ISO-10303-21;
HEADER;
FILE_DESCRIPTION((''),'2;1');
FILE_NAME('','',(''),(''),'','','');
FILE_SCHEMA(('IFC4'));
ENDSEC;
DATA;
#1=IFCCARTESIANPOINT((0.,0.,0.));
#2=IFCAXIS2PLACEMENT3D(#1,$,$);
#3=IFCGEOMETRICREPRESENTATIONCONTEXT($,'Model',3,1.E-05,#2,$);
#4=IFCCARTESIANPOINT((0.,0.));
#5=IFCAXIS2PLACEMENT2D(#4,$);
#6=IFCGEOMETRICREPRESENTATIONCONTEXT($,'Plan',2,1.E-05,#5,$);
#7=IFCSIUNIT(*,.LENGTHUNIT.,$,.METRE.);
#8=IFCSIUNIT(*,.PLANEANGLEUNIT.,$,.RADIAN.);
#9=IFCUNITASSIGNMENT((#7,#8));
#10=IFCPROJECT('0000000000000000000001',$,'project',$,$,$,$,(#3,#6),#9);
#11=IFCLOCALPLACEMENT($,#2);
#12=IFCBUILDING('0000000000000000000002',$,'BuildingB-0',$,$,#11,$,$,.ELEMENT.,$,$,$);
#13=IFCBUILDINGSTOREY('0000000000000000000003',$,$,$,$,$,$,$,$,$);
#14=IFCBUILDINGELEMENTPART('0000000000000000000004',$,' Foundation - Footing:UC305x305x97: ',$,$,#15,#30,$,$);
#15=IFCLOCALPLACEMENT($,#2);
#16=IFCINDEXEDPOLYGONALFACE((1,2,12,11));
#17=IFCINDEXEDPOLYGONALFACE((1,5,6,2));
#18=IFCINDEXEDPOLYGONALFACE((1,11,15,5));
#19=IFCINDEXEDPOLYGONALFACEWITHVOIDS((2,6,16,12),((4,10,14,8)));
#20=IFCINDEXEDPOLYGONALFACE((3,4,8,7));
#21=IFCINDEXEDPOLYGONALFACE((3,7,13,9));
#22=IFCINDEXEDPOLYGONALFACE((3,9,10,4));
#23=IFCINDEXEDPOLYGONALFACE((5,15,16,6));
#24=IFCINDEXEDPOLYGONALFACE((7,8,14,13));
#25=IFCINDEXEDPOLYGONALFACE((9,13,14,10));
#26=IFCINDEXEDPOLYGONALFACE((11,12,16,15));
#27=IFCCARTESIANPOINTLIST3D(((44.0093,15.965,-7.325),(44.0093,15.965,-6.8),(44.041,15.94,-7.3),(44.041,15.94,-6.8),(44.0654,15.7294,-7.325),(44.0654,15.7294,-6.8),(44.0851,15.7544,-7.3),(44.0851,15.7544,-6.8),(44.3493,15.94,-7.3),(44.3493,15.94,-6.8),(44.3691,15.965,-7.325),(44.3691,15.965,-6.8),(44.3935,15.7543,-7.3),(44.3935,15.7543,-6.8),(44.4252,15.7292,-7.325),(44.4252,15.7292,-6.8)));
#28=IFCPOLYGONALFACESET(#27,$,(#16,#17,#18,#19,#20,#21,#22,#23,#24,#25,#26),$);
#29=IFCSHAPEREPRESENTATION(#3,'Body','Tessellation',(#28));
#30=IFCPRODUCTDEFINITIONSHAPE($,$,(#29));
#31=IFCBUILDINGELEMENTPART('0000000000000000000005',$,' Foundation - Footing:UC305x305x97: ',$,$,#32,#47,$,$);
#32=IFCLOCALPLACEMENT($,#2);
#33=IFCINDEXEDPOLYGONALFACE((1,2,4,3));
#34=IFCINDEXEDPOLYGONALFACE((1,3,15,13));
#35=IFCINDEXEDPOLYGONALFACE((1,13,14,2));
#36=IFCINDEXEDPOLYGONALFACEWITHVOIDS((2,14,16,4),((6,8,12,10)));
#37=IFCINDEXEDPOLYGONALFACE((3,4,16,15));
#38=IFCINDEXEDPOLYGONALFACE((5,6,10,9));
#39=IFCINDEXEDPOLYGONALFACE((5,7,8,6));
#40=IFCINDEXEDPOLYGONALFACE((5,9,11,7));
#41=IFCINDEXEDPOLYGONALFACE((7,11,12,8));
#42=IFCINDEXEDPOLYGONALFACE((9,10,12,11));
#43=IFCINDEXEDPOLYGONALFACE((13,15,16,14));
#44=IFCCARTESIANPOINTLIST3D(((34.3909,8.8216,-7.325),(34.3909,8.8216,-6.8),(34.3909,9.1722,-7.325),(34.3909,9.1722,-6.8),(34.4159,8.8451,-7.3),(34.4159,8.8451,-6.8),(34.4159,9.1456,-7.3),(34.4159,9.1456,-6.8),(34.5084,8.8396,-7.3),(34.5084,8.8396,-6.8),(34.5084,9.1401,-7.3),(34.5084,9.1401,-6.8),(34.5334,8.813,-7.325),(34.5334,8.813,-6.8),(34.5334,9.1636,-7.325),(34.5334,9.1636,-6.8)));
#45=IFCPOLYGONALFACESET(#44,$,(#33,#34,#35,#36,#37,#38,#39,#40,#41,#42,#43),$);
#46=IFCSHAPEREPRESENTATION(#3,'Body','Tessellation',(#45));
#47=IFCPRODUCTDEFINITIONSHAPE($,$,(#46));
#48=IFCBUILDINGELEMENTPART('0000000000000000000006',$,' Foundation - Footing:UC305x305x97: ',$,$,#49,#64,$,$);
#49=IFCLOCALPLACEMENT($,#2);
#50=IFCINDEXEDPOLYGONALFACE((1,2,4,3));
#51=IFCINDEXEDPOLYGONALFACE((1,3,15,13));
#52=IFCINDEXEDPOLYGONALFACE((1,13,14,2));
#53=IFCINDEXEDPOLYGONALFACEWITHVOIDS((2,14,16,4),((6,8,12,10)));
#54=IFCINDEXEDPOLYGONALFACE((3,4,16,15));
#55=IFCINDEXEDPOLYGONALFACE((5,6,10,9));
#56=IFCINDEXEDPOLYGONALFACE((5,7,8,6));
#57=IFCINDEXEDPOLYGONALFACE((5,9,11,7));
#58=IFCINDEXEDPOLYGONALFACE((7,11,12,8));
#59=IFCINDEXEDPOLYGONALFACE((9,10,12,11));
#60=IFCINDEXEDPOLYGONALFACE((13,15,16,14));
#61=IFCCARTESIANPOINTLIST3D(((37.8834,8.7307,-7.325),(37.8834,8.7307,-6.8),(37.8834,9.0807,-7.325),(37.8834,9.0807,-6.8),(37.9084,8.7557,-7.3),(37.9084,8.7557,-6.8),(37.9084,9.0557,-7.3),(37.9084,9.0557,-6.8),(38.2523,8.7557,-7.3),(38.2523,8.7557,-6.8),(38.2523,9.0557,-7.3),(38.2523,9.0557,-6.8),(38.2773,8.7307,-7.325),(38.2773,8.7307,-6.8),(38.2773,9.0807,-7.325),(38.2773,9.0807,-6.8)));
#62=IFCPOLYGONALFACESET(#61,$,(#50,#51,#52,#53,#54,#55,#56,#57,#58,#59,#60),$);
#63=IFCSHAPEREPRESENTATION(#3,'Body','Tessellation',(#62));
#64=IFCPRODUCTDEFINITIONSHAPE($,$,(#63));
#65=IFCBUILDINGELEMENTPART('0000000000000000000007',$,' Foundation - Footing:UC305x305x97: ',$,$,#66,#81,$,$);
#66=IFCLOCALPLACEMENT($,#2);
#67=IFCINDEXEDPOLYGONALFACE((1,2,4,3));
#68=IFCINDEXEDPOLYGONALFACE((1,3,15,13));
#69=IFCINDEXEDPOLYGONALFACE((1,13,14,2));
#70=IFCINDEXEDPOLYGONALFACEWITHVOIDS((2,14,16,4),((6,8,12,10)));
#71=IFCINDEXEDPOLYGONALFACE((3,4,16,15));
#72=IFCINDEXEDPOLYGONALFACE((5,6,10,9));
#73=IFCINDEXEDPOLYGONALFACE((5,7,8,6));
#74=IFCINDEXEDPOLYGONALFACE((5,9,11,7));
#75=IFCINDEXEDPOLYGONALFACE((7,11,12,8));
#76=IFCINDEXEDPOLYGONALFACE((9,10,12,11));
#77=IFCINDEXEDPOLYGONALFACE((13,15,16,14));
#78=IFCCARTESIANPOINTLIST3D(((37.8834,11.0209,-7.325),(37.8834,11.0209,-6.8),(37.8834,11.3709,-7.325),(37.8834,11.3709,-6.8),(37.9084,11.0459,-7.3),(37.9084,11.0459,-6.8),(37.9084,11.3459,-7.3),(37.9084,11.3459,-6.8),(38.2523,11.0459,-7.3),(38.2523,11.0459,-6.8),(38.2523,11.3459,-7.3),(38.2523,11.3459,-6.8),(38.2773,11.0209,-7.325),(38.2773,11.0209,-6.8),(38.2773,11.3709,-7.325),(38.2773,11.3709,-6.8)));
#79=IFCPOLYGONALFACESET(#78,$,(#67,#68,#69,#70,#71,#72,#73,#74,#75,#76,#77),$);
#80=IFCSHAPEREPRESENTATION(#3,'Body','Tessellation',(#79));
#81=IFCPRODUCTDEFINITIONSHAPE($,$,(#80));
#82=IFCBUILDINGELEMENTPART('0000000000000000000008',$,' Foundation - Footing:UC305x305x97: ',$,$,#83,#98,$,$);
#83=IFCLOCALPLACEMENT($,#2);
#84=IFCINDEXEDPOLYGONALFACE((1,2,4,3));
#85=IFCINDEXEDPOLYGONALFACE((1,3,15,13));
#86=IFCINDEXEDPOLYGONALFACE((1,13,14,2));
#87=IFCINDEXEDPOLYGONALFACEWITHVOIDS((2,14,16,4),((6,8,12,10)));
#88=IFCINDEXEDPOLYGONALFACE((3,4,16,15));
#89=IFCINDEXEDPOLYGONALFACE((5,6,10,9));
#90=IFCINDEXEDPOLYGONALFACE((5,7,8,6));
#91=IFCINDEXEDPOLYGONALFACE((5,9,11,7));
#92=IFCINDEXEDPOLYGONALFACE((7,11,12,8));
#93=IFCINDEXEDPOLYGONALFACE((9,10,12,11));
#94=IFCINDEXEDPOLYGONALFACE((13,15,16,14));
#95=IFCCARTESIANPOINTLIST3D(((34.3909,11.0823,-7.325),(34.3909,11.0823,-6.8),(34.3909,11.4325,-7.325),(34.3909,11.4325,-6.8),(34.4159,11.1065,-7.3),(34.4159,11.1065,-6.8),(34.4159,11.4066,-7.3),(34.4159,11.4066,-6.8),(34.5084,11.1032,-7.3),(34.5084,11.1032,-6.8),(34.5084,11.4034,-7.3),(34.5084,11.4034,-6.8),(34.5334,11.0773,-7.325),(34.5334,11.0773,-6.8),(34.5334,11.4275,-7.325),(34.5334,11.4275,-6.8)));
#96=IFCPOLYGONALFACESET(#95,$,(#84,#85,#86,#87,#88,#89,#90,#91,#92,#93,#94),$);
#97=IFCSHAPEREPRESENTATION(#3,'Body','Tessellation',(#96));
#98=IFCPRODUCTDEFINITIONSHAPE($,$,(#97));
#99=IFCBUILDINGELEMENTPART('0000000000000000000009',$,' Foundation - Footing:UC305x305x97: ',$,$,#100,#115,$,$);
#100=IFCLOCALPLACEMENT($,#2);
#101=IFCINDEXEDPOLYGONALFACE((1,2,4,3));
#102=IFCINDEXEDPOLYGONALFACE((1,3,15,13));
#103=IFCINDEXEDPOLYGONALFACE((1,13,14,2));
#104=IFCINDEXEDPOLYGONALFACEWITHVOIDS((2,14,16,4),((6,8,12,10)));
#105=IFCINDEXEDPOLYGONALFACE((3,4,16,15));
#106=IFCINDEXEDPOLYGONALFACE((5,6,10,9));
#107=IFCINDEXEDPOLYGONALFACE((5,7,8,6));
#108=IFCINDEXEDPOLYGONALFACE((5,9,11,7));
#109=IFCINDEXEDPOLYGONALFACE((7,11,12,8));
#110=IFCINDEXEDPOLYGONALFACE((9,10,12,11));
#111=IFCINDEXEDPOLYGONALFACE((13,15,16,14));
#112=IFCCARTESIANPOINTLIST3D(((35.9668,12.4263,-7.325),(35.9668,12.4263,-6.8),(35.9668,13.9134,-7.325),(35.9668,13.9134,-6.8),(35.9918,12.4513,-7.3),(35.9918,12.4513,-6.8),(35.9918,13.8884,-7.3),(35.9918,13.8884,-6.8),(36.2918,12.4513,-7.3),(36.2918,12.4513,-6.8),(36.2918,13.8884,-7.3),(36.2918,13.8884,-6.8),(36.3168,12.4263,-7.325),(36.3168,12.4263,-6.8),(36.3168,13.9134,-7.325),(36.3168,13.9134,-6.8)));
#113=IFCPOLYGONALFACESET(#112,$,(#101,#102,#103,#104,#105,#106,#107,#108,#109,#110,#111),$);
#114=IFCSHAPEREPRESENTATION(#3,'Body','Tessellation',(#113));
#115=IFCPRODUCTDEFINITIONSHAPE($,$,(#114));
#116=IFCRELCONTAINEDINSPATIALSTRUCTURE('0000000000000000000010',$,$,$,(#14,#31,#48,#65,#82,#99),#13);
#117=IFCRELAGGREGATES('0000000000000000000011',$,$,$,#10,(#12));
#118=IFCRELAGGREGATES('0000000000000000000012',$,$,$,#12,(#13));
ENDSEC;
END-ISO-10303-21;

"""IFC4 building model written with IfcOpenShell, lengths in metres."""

from ifc_helpers import new_model, si_unit, origin, origin_2d, place, context, project, spatial, polyline, outline, extrude, element, save


model = new_model("IFC4")

# Units and contexts
model_context = context("Model", 3, precision=1e-05, world=origin())
plan_context = context("Plan", 2, precision=1e-05, world=origin_2d())
ifc_project = project(units=[si_unit("LENGTHUNIT", "METRE"), si_unit("PLANEANGLEUNIT", "RADIAN")], contexts=[model_context, plan_context])

# Building, storey
building_placement = place(None, origin())
building = spatial("IfcBuilding", under=ifc_project, at=building_placement, Name="BuildingB-0", CompositionType="ELEMENT")
storey = spatial("IfcBuildingStorey", under=building)

# Building element parts, openings
building_element_part_1 = element("IfcBuildingElementPart", 1, inside=storey, Name=" Foundation - Footing:UC305x305x97: ", context=model_context, shape_type="SweptSolid", body=[
    extrude(outline(polyline([(44.0654, 15.7294, -7.325), (44.0093, 15.965, -7.325), (44.3691, 15.965, -7.325), (44.4252, 15.7292, -7.325), (44.0654, 15.7294, -7.325)])), None, (0.0, 0.0, 1.0), 0.525),
])
element("IfcOpeningElement", 2, inside=storey, cuts=building_element_part_1, context=model_context, shape_type="SweptSolid", body=[
    extrude(outline(polyline([(44.0851, 15.7544, -7.3), (44.041, 15.94, -7.3), (44.3493, 15.94, -7.3), (44.3935, 15.7543, -7.3), (44.0851, 15.7544, -7.3)])), None, (0.0, 0.0, 1.0), 0.5),
])
building_element_part_2 = element("IfcBuildingElementPart", 3, inside=storey, Name=" Foundation - Footing:UC305x305x97: ", context=model_context, shape_type="SweptSolid", body=[
    extrude(outline(polyline([(34.3909, 8.8216, -7.325), (34.5334, 8.813, -7.325), (34.5334, 9.1636, -7.325), (34.3909, 9.1722, -7.325), (34.3909, 8.8216, -7.325)])), None, (0.0, 0.0, 1.0), 0.525),
])
element("IfcOpeningElement", 4, inside=storey, cuts=building_element_part_2, context=model_context, shape_type="SweptSolid", body=[
    extrude(outline(polyline([(34.4159, 8.8451, -7.3), (34.5084, 8.8396, -7.3), (34.5084, 9.1401, -7.3), (34.4159, 9.1456, -7.3), (34.4159, 8.8451, -7.3)])), None, (0.0, 0.0, 1.0), 0.5),
])
building_element_part_3 = element("IfcBuildingElementPart", 5, inside=storey, Name=" Foundation - Footing:UC305x305x97: ", context=model_context, shape_type="SweptSolid", body=[
    extrude(outline(polyline([(37.8834, 8.7307, -7.325), (38.2773, 8.7307, -7.325), (38.2773, 9.0807, -7.325), (37.8834, 9.0807, -7.325), (37.8834, 8.7307, -7.325)])), None, (0.0, 0.0, 1.0), 0.525),
])
element("IfcOpeningElement", 6, inside=storey, cuts=building_element_part_3, context=model_context, shape_type="SweptSolid", body=[
    extrude(outline(polyline([(37.9084, 8.7557, -7.3), (38.2523, 8.7557, -7.3), (38.2523, 9.0557, -7.3), (37.9084, 9.0557, -7.3), (37.9084, 8.7557, -7.3)])), None, (0.0, 0.0, 1.0), 0.5),
])
building_element_part_4 = element("IfcBuildingElementPart", 7, inside=storey, Name=" Foundation - Footing:UC305x305x97: ", context=model_context, shape_type="SweptSolid", body=[
    extrude(outline(polyline([(37.8834, 11.0209, -7.325), (38.2773, 11.0209, -7.325), (38.2773, 11.3709, -7.325), (37.8834, 11.3709, -7.325), (37.8834, 11.0209, -7.325)])), None, (0.0, 0.0, 1.0), 0.525),
])
element("IfcOpeningElement", 8, inside=storey, cuts=building_element_part_4, context=model_context, shape_type="SweptSolid", body=[
    extrude(outline(polyline([(37.9084, 11.0459, -7.3), (38.2523, 11.0459, -7.3), (38.2523, 11.3459, -7.3), (37.9084, 11.3459, -7.3), (37.9084, 11.0459, -7.3)])), None, (0.0, 0.0, 1.0), 0.5),
])
building_element_part_5 = element("IfcBuildingElementPart", 9, inside=storey, Name=" Foundation - Footing:UC305x305x97: ", context=model_context, shape_type="SweptSolid", body=[
    extrude(outline(polyline([(34.3909, 11.0823, -7.325), (34.5334, 11.0773, -7.325), (34.5334, 11.4275, -7.325), (34.3909, 11.4325, -7.325), (34.3909, 11.0823, -7.325)])), None, (0.0, 0.0, 1.0), 0.525),
])
element("IfcOpeningElement", 10, inside=storey, cuts=building_element_part_5, context=model_context, shape_type="SweptSolid", body=[
    extrude(outline(polyline([(34.4159, 11.1065, -7.3), (34.5084, 11.1032, -7.3), (34.5084, 11.4034, -7.3), (34.4159, 11.4066, -7.3), (34.4159, 11.1065, -7.3)])), None, (0.0, 0.0, 1.0), 0.5),
])
building_element_part_6 = element("IfcBuildingElementPart", 11, inside=storey, Name=" Foundation - Footing:UC305x305x97: ", context=model_context, shape_type="SweptSolid", body=[
    extrude(outline(polyline([(35.9668, 12.4263, -7.325), (36.3168, 12.4263, -7.325), (36.3168, 13.9134, -7.325), (35.9668, 13.9134, -7.325), (35.9668, 12.4263, -7.325)])), None, (0.0, 0.0, 1.0), 0.525),
])
element("IfcOpeningElement", 12, inside=storey, cuts=building_element_part_6, context=model_context, shape_type="SweptSolid", body=[
    extrude(outline(polyline([(35.9918, 12.4513, -7.3), (36.2918, 12.4513, -7.3), (36.2918, 13.8884, -7.3), (35.9918, 13.8884, -7.3), (35.9918, 12.4513, -7.3)])), None, (0.0, 0.0, 1.0), 0.5),
])

save(model, "model.ifc")
